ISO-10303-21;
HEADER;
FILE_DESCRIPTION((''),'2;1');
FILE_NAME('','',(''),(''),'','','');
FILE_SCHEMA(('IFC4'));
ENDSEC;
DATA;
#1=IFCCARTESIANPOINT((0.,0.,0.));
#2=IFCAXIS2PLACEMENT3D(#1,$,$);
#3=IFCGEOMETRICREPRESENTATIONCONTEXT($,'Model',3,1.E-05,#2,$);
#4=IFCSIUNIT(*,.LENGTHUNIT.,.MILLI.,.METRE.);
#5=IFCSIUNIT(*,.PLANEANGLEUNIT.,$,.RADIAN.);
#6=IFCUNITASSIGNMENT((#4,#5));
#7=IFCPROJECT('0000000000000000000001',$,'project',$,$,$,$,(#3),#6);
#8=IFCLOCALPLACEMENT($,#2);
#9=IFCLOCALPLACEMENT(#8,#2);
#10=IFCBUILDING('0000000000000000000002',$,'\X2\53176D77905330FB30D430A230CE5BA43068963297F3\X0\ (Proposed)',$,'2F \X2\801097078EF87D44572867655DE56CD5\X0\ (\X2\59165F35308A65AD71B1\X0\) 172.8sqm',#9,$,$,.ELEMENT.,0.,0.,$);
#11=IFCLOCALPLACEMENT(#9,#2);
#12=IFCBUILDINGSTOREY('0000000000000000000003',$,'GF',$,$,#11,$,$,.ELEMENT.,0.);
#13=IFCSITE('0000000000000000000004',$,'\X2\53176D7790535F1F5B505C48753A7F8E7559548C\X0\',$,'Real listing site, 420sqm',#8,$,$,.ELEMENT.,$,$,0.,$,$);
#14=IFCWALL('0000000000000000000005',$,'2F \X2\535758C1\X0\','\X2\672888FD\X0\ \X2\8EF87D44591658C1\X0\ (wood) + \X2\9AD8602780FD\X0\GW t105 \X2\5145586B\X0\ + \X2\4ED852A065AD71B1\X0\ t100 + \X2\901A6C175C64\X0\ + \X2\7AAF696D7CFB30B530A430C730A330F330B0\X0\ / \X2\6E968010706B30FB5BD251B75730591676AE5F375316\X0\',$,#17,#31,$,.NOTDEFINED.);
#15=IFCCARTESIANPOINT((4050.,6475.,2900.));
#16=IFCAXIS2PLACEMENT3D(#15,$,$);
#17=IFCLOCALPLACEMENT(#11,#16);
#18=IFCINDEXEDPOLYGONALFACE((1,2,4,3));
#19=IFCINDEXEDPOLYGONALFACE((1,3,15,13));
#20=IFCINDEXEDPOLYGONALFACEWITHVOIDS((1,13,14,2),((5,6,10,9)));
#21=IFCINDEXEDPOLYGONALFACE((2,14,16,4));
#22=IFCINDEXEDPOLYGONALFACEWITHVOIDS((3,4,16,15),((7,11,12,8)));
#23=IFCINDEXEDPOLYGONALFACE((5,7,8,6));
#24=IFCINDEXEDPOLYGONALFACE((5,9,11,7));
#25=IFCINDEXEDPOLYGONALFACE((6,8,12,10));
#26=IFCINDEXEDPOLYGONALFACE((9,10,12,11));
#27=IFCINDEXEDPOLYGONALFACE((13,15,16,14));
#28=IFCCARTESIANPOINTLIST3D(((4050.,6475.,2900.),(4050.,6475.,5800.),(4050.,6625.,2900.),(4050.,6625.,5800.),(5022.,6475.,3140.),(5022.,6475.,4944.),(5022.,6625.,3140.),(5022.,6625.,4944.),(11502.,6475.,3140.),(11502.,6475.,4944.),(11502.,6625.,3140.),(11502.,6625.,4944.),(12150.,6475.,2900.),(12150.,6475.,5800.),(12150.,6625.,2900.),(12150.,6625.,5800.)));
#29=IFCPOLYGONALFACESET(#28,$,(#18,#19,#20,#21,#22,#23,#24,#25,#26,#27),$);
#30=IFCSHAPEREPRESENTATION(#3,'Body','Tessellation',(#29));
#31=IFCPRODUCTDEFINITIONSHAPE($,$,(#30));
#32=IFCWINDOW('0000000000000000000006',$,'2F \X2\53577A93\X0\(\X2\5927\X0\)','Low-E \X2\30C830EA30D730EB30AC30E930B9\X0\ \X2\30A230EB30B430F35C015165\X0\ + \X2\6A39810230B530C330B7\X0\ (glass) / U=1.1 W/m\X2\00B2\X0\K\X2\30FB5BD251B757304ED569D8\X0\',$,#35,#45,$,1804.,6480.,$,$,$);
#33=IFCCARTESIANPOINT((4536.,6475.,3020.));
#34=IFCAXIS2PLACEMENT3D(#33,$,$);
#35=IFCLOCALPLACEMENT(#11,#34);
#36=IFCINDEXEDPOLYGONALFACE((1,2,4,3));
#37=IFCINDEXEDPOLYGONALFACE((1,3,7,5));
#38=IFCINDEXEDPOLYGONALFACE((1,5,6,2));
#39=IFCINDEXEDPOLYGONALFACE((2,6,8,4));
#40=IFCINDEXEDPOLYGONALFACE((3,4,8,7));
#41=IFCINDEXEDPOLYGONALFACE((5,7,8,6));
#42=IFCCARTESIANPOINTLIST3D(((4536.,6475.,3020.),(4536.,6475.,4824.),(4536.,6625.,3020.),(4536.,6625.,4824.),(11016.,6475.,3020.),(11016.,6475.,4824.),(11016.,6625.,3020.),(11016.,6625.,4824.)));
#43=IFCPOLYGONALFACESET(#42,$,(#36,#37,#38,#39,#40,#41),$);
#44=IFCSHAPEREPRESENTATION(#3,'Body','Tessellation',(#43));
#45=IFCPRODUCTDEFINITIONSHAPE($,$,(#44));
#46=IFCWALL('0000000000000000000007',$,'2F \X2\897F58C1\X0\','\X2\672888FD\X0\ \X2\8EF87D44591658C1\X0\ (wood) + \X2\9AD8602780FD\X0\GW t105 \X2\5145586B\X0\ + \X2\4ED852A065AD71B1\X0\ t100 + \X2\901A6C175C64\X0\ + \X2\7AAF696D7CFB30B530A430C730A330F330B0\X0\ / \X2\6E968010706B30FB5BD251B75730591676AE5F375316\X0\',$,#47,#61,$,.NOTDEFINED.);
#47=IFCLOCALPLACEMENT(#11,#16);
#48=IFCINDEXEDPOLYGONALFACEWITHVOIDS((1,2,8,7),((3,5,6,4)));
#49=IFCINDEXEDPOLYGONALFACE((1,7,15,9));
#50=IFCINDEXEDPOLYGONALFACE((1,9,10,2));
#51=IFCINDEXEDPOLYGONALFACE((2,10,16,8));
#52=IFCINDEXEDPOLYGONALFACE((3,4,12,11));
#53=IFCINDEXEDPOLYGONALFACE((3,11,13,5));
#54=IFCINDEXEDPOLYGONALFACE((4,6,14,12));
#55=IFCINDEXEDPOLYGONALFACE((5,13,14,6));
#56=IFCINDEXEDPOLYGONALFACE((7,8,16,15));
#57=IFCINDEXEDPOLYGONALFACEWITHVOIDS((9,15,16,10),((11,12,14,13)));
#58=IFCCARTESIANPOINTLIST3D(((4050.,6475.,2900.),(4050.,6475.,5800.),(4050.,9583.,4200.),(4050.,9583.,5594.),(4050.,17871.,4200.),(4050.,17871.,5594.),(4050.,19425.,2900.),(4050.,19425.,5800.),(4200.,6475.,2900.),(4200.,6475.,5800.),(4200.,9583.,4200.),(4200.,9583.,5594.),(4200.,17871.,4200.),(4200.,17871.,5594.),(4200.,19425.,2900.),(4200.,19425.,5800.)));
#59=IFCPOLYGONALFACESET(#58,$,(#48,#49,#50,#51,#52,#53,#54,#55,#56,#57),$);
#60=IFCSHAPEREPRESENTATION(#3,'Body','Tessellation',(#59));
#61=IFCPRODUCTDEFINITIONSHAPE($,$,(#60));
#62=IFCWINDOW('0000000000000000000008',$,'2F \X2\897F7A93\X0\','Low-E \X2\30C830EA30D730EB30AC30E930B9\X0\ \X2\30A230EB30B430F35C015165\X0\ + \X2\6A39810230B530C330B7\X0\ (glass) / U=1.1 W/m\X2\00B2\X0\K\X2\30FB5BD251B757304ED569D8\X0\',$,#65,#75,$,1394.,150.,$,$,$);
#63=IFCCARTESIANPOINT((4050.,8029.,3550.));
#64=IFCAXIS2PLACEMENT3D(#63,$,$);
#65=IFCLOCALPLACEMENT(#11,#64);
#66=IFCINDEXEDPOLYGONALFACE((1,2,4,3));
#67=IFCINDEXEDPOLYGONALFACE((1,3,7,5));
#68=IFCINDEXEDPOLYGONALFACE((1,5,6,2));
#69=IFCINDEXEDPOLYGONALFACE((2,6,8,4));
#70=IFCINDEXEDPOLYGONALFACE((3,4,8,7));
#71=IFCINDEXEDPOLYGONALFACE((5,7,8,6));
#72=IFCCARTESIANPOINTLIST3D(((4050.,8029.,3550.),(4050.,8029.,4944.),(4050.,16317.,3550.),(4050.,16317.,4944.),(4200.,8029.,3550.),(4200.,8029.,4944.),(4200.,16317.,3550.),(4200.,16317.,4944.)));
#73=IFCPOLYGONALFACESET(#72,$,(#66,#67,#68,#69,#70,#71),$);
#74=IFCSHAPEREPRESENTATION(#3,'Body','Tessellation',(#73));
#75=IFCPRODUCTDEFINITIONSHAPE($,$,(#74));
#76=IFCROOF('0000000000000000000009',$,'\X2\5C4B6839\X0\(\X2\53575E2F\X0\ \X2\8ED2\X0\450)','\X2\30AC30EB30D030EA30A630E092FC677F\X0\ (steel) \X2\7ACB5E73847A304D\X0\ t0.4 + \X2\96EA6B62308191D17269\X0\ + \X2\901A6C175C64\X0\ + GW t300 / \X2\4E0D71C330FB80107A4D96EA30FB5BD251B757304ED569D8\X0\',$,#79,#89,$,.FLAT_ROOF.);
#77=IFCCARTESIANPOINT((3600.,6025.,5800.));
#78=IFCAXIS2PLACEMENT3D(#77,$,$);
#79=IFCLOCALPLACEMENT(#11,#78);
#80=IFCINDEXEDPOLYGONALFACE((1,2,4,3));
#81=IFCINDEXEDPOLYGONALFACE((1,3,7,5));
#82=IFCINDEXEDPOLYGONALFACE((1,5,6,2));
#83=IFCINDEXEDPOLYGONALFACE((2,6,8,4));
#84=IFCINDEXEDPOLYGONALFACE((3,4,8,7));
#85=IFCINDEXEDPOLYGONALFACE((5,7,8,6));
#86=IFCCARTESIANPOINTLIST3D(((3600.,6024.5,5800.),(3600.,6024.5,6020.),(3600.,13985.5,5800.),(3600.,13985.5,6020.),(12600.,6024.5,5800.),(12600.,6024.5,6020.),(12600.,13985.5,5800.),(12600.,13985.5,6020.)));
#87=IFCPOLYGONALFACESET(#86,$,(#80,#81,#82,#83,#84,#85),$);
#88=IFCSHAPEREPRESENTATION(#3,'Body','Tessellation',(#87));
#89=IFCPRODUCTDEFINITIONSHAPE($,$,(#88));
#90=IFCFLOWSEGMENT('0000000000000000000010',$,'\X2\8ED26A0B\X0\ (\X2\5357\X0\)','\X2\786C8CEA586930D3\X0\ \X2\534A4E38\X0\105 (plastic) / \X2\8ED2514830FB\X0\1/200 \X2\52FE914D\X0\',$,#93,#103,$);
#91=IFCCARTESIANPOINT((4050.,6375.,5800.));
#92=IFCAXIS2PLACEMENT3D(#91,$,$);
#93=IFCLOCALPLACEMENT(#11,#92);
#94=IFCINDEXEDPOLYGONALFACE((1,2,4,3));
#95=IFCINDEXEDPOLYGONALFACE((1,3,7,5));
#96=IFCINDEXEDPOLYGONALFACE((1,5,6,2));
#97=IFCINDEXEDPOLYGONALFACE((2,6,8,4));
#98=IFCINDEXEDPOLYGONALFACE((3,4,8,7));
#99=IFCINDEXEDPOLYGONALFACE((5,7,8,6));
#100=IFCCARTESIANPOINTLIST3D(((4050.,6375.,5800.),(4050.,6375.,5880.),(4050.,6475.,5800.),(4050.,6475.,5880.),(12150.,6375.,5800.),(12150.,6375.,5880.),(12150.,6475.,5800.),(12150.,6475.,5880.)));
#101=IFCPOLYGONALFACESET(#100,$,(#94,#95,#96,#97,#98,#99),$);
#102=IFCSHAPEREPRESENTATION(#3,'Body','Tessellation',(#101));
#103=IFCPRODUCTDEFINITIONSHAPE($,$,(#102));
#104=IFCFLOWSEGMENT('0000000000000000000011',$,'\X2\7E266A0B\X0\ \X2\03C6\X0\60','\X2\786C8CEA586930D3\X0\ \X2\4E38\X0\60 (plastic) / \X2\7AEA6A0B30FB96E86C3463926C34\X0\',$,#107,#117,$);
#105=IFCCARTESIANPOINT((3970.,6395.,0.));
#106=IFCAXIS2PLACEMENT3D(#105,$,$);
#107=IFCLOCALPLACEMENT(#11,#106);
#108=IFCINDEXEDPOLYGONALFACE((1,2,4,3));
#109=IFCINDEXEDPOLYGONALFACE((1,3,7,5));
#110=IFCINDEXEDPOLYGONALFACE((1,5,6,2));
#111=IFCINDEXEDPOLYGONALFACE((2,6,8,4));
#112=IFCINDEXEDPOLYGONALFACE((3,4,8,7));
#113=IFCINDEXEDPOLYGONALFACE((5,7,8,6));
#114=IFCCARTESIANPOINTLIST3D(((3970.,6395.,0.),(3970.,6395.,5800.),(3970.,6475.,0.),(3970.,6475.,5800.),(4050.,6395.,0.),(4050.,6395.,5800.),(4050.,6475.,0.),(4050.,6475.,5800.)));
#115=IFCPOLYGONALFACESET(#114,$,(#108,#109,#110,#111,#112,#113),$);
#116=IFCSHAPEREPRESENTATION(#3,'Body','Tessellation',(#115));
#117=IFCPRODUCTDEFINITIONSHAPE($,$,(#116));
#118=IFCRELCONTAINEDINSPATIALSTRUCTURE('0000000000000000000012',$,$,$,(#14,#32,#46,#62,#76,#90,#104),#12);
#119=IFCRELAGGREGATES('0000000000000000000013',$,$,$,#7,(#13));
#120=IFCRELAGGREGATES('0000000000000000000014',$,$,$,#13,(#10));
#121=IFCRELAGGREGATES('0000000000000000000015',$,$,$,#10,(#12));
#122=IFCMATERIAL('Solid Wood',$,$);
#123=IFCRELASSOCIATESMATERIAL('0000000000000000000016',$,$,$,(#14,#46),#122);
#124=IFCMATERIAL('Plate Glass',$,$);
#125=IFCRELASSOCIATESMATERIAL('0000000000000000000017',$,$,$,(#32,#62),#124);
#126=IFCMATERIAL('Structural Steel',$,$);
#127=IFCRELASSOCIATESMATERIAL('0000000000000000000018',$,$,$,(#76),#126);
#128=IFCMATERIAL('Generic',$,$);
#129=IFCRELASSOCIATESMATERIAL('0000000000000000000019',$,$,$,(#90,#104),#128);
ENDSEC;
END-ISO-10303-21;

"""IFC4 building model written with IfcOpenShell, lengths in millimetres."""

from ifc_helpers import new_model, si_unit, frame, frame_2d, origin, place, context, project, spatial, rectangle, extrude, material, element, fill, save


model = new_model("IFC4")

# Units and contexts
model_context = context("Model", 3, precision=1e-05, world=origin())
ifc_project = project(units=[si_unit("LENGTHUNIT", "METRE", prefix="MILLI"), si_unit("PLANEANGLEUNIT", "RADIAN")], contexts=[model_context])

# Site, building, storey
site_placement = place(None, origin())
site = spatial("IfcSite", under=ifc_project, at=site_placement, Name="北海道弟子屈町美留和", ObjectType="Real listing site, 420sqm", CompositionType="ELEMENT", RefElevation=0.0)
building_placement = place(site_placement, origin())
building = spatial("IfcBuilding", under=site, at=building_placement, Name="北海道・ピアノ室と防音 (Proposed)", ObjectType="2F 耐震軸組在来工法 (外張り断熱) 172.8sqm", CompositionType="ELEMENT", ElevationOfRefHeight=0.0, ElevationOfTerrain=0.0)
storey_placement = place(building_placement, origin())
storey = spatial("IfcBuildingStorey", under=building, at=storey_placement, Name="GF", CompositionType="ELEMENT", Elevation=0.0)

# Shared definitions
ifc_material_1 = material(Name="Solid Wood")

# Shared definitions
ifc_material_2 = material(Name="Plate Glass")

# Walls, openings, windows
wall_1_placement = place(storey_placement, frame((4050.0, 6475.0, 2900.0)))
wall_1 = element("IfcWall", 1, at=wall_1_placement, inside=storey, material=ifc_material_1, Name="2F 南壁", Description="木製 軸組外壁 (wood) + 高性能GW t105 充填 + 付加断熱 t100 + 通気層 + 窯業系サイディング / 準耐火・寒冷地外皮強化", PredefinedType="NOTDEFINED", context=model_context, shape_type="SweptSolid", body=[
    extrude(rectangle(XDim=8100.0, YDim=150.0, at=frame_2d((4050.0, 75.0))), frame((4050.0, 6475.0, 2900.0)), (0.0, 0.0, 1.0), 2900.0),
])
opening_1_placement = place(storey_placement, frame((4536.0, 6475.0, 3020.0)))
opening_1 = element("IfcOpeningElement", 2, at=opening_1_placement, cuts=wall_1, PredefinedType="NOTDEFINED", context=model_context, shape_type="SweptSolid", body=[
    extrude(rectangle(XDim=6480.0, YDim=150.0, at=frame_2d((3240.0, 75.0))), frame((4536.0, 6475.0, 3020.0)), (0.0, 0.0, 1.0), 1804.0),
])
window_1_placement = place(storey_placement, frame((4536.0, 6475.0, 3020.0)))
window_1 = element("IfcWindow", 3, at=window_1_placement, inside=storey, material=ifc_material_2, Name="2F 南窓(大)", Description="Low-E トリプルガラス アルゴン封入 + 樹脂サッシ (glass) / U=1.1 W/m²K・寒冷地仕様", OverallHeight=1804.0, OverallWidth=6480.0, context=model_context, shape_type="SweptSolid", body=[
    extrude(rectangle(XDim=6480.0, YDim=150.0, at=frame_2d((3240.0, 75.0))), frame((4536.0, 6475.0, 3020.0)), (0.0, 0.0, 1.0), 1804.0),
])
fill(opening_1, window_1)
wall_2_placement = place(storey_placement, frame((4050.0, 6475.0, 2900.0)))
wall_2 = element("IfcWall", 4, at=wall_2_placement, inside=storey, material=ifc_material_1, Name="2F 西壁", Description="木製 軸組外壁 (wood) + 高性能GW t105 充填 + 付加断熱 t100 + 通気層 + 窯業系サイディング / 準耐火・寒冷地外皮強化", PredefinedType="NOTDEFINED", context=model_context, shape_type="SweptSolid", body=[
    extrude(rectangle(XDim=150.0, YDim=12950.0, at=frame_2d((75.0, 6475.0))), frame((4050.0, 6475.0, 2900.0)), (0.0, 0.0, 1.0), 2900.0),
])
opening_2_placement = place(storey_placement, frame((4050.0, 8029.0, 3550.0)))
opening_2 = element("IfcOpeningElement", 5, at=opening_2_placement, cuts=wall_2, PredefinedType="NOTDEFINED", context=model_context, shape_type="SweptSolid", body=[
    extrude(rectangle(XDim=150.0, YDim=8288.0, at=frame_2d((75.0, 4144.0))), frame((4050.0, 8029.0, 3550.0)), (0.0, 0.0, 1.0), 1394.0),
])
window_2_placement = place(storey_placement, frame((4050.0, 8029.0, 3550.0)))
window_2 = element("IfcWindow", 6, at=window_2_placement, inside=storey, material=ifc_material_2, Name="2F 西窓", Description="Low-E トリプルガラス アルゴン封入 + 樹脂サッシ (glass) / U=1.1 W/m²K・寒冷地仕様", OverallHeight=1394.0, OverallWidth=150.0, context=model_context, shape_type="SweptSolid", body=[
    extrude(rectangle(XDim=150.0, YDim=8288.0, at=frame_2d((75.0, 4144.0))), frame((4050.0, 8029.0, 3550.0)), (0.0, 0.0, 1.0), 1394.0),
])
fill(opening_2, window_2)

# Roof
ifc_material_3 = material(Name="Structural Steel")
for number, where, name in (
    (7, (3600.0, 6025.0, 5800.0), "屋根(南帯 軒450)"),
):
    element("IfcRoof", number, at=place(storey_placement, frame(where)), inside=storey, material=ifc_material_3, Name=name, Description="ガルバリウム鋼板 (steel) 立平葺き t0.4 + 雪止め金物 + 通気層 + GW t300 / 不燃・耐積雪・寒冷地仕様", PredefinedType="FLAT_ROOF", context=model_context, shape_type="SweptSolid", body=[
        extrude(rectangle(XDim=9000.0, YDim=7961.0, at=frame_2d((4500.0, 3980.0))), frame((3600.0, 6025.0, 5800.0)), (0.0, 0.0, 1.0), 220.0),
    ])

# Flow segments
ifc_material_4 = material(Name="Generic")
flow_segment_1_placement = place(storey_placement, frame((4050.0, 6375.0, 5800.0)))
element("IfcFlowSegment", 8, at=flow_segment_1_placement, inside=storey, material=ifc_material_4, Name="軒樋 (南)", Description="硬質塩ビ 半丸105 (plastic) / 軒先・1/200 勾配", context=model_context, shape_type="SweptSolid", body=[
    extrude(rectangle(XDim=8100.0, YDim=100.0, at=frame_2d((4050.0, 50.0))), frame((4050.0, 6375.0, 5800.0)), (0.0, 0.0, 1.0), 80.0),
])
flow_segment_2_placement = place(storey_placement, frame((3970.0, 6395.0, 0.0)))
element("IfcFlowSegment", 9, at=flow_segment_2_placement, inside=storey, material=ifc_material_4, Name="縦樋 φ60", Description="硬質塩ビ 丸60 (plastic) / 竪樋・雨水排水", context=model_context, shape_type="SweptSolid", body=[
    extrude(rectangle(XDim=80.0, YDim=80.0, at=frame_2d((40.0, 40.0))), frame((3970.0, 6395.0, 0.0)), (0.0, 0.0, 1.0), 5800.0),
])

save(model, "model.ifc")
